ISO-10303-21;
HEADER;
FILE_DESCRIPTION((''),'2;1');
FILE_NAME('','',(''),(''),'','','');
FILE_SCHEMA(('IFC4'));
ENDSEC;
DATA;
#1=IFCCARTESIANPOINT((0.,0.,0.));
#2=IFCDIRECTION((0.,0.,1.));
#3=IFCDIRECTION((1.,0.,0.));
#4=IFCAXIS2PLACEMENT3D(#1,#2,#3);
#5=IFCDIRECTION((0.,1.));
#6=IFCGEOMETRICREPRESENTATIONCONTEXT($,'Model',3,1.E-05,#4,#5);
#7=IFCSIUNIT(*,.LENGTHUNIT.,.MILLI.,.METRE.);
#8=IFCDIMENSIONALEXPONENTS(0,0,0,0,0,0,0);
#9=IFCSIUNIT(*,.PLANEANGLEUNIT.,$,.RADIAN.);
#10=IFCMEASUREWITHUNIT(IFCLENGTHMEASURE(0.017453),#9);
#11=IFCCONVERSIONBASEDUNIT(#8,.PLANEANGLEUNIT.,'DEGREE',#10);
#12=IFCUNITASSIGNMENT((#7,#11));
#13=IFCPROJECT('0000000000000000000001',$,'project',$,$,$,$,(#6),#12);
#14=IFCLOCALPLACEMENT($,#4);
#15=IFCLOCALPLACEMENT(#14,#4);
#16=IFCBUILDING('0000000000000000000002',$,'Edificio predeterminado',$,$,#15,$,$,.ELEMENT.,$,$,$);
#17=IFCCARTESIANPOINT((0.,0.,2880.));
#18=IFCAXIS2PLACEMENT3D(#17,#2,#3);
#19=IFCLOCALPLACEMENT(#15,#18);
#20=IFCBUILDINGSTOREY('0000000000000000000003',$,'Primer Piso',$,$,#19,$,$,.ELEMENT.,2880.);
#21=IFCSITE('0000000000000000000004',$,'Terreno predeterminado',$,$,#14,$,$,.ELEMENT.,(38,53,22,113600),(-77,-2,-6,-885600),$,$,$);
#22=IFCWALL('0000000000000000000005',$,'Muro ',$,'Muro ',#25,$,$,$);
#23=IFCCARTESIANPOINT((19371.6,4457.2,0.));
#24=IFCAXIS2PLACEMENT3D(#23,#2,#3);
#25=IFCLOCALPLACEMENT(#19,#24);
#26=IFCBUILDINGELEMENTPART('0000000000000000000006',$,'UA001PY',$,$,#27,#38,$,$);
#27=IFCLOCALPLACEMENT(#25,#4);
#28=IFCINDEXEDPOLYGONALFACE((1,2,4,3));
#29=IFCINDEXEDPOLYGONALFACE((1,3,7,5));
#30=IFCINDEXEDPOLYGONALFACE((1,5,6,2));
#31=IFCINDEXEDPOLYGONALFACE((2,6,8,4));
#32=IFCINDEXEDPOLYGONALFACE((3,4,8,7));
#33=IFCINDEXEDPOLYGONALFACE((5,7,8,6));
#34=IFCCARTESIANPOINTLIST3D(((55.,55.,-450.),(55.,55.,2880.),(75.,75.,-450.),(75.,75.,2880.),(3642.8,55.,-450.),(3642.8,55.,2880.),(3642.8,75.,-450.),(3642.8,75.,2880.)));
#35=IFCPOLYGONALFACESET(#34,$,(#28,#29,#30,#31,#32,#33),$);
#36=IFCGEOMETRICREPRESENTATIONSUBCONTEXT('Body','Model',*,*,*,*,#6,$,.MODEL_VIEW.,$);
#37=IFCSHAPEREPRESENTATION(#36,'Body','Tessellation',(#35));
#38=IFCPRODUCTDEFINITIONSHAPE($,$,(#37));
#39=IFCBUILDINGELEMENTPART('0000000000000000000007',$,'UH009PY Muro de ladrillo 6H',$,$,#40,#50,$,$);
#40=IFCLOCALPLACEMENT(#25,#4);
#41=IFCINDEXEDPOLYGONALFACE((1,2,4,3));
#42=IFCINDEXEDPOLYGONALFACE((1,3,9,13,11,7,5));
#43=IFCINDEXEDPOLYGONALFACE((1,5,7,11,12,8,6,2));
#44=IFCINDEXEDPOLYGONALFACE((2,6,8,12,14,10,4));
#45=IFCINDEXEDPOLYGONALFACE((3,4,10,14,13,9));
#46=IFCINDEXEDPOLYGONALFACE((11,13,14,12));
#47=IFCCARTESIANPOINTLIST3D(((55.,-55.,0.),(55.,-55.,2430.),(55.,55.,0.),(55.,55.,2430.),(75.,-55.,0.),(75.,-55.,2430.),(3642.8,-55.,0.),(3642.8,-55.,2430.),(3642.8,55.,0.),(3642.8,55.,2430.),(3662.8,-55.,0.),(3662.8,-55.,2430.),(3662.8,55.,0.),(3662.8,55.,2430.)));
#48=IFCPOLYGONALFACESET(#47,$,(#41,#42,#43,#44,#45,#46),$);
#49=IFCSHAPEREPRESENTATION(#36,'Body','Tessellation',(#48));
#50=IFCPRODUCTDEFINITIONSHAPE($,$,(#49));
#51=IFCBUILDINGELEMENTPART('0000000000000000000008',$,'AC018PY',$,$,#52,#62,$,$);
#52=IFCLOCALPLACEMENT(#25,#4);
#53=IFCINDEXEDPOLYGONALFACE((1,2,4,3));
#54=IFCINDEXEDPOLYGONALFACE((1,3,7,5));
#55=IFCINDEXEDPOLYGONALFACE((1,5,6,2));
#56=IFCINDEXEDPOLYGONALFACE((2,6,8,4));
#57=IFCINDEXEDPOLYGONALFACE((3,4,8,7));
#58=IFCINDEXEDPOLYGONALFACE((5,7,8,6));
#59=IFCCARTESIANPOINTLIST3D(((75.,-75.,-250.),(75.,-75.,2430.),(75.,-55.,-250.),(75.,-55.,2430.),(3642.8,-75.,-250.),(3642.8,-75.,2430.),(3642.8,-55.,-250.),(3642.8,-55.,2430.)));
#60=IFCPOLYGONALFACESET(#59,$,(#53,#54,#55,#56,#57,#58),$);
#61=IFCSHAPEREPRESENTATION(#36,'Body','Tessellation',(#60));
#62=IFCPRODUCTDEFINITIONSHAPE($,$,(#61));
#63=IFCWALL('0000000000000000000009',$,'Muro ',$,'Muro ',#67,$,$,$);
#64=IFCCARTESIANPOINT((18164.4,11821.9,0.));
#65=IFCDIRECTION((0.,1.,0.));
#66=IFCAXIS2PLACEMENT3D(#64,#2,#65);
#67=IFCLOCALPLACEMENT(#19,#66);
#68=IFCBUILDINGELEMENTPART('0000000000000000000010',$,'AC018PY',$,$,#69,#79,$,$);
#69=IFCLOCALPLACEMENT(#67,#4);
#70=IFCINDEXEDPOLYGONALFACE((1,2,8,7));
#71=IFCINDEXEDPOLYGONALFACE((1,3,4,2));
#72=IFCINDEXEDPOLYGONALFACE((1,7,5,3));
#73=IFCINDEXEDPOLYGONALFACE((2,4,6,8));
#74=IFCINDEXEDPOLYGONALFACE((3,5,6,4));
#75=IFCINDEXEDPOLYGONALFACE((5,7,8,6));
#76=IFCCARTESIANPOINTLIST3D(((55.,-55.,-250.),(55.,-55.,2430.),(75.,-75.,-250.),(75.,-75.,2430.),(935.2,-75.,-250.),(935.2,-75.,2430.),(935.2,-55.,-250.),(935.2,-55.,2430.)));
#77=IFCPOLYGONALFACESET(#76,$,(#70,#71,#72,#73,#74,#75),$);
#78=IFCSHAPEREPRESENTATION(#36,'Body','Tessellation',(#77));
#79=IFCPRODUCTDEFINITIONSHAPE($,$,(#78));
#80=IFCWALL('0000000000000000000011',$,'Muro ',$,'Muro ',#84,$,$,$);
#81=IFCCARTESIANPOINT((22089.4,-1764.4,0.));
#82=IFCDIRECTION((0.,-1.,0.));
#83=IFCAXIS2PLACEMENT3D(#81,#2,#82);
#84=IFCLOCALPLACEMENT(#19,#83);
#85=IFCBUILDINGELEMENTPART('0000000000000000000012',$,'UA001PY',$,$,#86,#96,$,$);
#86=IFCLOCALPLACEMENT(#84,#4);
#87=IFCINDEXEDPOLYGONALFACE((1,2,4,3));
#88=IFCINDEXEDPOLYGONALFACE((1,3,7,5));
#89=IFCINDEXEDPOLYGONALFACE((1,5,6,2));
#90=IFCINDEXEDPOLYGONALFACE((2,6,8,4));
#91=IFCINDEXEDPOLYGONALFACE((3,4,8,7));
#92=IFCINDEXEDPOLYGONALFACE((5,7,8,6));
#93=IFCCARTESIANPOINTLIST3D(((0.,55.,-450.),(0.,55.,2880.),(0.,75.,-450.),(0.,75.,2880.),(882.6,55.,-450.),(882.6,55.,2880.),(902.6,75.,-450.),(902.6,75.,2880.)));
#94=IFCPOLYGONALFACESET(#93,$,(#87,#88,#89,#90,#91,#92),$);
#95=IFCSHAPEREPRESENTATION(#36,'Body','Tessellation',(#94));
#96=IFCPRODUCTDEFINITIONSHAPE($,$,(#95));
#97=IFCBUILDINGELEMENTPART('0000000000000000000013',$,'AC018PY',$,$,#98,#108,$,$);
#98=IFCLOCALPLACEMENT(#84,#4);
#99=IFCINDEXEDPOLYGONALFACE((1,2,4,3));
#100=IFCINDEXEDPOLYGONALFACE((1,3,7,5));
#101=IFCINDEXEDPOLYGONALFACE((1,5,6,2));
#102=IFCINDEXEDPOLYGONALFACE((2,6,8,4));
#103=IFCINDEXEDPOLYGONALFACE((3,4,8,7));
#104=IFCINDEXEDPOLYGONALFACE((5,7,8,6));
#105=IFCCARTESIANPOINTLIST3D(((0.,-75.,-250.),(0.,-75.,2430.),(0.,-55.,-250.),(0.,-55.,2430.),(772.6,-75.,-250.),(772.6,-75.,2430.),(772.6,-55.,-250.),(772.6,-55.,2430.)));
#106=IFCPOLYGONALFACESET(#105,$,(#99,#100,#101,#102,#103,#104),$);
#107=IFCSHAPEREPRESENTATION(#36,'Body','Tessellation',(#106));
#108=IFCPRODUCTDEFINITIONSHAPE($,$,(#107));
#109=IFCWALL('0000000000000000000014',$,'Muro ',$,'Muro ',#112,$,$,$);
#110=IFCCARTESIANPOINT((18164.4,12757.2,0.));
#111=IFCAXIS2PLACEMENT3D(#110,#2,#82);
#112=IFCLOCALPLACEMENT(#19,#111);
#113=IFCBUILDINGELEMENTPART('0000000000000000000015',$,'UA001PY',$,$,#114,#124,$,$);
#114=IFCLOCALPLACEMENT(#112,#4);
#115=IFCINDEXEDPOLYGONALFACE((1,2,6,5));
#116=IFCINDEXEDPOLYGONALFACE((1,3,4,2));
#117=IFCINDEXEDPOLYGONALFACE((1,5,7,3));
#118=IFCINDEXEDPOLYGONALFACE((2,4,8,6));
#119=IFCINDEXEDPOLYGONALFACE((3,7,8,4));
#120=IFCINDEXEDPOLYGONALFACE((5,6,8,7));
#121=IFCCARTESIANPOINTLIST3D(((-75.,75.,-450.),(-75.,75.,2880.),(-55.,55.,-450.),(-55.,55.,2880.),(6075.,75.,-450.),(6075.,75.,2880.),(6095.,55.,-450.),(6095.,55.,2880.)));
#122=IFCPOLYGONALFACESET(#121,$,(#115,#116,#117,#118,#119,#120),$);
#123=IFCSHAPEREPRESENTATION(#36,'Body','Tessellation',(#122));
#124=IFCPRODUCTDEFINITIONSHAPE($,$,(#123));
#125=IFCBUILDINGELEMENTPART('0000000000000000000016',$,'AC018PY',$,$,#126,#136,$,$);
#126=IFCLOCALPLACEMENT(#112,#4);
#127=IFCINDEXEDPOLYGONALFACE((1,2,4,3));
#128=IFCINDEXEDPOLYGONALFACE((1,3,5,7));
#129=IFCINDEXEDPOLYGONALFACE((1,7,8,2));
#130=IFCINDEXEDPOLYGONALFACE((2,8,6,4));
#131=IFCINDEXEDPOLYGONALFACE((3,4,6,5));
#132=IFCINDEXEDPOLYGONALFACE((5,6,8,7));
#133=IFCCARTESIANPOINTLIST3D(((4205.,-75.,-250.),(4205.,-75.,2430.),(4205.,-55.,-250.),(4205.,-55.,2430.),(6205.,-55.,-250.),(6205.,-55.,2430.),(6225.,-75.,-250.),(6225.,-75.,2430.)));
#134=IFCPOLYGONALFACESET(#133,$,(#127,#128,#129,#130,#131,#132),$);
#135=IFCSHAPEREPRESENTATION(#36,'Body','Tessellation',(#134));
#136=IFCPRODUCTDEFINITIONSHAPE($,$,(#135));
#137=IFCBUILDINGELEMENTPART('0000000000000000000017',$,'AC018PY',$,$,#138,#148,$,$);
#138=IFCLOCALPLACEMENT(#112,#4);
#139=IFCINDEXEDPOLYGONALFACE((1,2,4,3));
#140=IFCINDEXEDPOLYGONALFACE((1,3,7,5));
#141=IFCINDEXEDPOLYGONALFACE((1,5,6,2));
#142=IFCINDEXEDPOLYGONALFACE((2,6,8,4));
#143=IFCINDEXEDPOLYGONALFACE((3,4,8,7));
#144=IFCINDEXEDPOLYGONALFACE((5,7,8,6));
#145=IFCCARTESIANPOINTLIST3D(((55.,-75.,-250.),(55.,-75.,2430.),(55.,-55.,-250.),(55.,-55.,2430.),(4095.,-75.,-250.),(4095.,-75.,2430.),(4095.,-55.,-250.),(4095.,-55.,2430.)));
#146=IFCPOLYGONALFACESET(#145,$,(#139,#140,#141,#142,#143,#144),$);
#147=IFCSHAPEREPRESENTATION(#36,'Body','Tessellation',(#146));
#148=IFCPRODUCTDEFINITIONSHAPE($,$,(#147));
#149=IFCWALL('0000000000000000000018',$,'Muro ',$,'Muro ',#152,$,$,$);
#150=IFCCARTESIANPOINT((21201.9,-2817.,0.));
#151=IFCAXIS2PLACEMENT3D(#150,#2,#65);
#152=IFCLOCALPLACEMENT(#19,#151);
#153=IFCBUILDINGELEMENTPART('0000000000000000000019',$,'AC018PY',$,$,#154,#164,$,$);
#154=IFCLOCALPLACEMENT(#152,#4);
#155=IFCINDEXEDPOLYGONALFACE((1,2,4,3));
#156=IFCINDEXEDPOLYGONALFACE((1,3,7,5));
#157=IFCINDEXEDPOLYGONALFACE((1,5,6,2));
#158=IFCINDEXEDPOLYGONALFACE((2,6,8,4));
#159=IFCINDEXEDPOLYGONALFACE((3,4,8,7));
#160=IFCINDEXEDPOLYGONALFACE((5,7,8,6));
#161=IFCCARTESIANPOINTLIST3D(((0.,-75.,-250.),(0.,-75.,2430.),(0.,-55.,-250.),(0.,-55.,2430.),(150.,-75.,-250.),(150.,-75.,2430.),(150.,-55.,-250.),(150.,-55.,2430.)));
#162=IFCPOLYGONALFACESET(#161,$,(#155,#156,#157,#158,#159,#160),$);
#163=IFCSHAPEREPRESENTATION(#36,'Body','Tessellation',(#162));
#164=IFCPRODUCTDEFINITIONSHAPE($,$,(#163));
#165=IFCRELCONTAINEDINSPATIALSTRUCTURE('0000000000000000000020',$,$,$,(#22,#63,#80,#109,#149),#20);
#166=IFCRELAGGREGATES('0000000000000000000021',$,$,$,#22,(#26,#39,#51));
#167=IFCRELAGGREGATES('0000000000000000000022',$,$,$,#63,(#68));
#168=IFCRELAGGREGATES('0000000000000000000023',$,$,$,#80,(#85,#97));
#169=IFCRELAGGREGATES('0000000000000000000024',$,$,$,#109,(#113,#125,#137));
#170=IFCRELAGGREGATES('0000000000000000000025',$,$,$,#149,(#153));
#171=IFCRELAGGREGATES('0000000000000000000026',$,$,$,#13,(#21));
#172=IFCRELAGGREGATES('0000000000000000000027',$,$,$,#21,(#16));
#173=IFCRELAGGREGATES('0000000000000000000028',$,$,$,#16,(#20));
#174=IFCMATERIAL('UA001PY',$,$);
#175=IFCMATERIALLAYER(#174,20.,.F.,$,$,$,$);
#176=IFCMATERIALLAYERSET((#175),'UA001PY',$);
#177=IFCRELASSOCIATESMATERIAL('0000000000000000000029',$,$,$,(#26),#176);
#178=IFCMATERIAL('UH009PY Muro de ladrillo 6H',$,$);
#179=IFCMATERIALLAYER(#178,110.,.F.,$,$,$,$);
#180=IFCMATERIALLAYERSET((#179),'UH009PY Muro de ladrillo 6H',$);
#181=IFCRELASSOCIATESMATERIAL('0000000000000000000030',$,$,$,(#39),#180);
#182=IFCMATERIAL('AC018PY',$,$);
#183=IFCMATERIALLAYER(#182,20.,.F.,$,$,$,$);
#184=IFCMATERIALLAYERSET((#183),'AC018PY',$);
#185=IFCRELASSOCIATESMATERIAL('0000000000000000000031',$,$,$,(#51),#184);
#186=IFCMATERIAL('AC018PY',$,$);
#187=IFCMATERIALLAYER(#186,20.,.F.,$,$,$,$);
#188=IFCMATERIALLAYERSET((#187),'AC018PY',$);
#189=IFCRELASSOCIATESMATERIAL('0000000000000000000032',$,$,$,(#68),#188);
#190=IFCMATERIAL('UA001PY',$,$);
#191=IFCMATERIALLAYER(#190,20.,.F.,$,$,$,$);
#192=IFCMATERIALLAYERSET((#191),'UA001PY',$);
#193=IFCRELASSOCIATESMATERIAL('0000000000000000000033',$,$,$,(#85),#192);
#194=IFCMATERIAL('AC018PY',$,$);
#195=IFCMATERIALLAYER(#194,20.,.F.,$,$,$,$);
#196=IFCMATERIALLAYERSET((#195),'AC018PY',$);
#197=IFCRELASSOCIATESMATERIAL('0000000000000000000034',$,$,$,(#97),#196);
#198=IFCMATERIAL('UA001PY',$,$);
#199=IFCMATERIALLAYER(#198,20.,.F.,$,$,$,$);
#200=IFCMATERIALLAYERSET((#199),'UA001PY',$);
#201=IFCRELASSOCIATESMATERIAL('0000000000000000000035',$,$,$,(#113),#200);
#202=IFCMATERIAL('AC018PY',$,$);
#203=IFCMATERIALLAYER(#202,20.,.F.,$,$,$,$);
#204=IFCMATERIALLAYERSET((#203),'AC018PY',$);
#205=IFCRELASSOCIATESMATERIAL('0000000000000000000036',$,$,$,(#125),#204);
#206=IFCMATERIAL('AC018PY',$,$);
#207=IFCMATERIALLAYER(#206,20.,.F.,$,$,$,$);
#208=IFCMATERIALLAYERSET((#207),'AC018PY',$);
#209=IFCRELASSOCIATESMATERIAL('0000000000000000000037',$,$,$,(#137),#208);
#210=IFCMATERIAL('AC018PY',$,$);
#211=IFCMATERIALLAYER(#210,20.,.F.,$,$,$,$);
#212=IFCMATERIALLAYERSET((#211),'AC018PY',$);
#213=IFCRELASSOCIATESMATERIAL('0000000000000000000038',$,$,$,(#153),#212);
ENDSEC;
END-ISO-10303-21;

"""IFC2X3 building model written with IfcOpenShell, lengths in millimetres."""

from ifc_helpers import new_model, entity, si_unit, converted_unit, direction, frame, origin_with_axes, place, context, subcontext, project, spatial, polyline, outline, extrude, clip, bounded_halfspace, material, layer, layer_set, layer_usage, element, aggregate, save


model = new_model("IFC2X3")

# Units and contexts
model_context = context("Model", 3, precision=1e-05, world=origin_with_axes(), true_north=direction((0.0, 1.0)))
body_context = subcontext(model_context, "Body", "Model", "MODEL_VIEW")
ifc_project = project(units=[si_unit("LENGTHUNIT", "METRE", prefix="MILLI"), converted_unit("PLANEANGLEUNIT", "DEGREE", entity("IfcLengthMeasure", 0.017453), si_unit("PLANEANGLEUNIT", "RADIAN"), dimensions=[0, 0, 0, 0, 0, 0, 0])], contexts=[model_context])

# Site, building, storey
site_placement = place(None, origin_with_axes())
site = spatial("IfcSite", under=ifc_project, at=site_placement, Name="Terreno predeterminado", CompositionType="ELEMENT", RefLatitude=(38, 53, 22, 113600), RefLongitude=(-77, -2, -6, -885600))
building_placement = place(site_placement, origin_with_axes())
building = spatial("IfcBuilding", under=site, at=building_placement, Name="Edificio predeterminado", CompositionType="ELEMENT")
storey_placement = place(building_placement, frame((0.0, 0.0, 2880.0), z_axis=(0.0, 0.0, 1.0), x_axis=(1.0, 0.0, 0.0)))
storey = spatial("IfcBuildingStorey", under=building, at=storey_placement, Name="Primer Piso", CompositionType="ELEMENT", Elevation=2880.0)

# Walls, building element parts
wall_1_placement = place(storey_placement, frame((19371.6, 4457.2, 0.0), z_axis=(0.0, 0.0, 1.0), x_axis=(1.0, 0.0, 0.0)))
wall_1 = element("IfcWall", 1, at=wall_1_placement, inside=storey, Name="Muro ", ObjectType="Muro ")
ifc_material_1 = material(Name="UA001PY")
ifc_layer_1 = layer(ifc_material_1, 20.0, ventilated=False)
ifc_layer_set_1 = layer_set([ifc_layer_1], Name="UA001PY")
ifc_layer_usage_1 = layer_usage(ifc_layer_set_1, "AXIS2", "NEGATIVE", -75.0)
building_element_part_1_placement = place(wall_1_placement, origin_with_axes())
building_element_part_1 = element("IfcBuildingElementPart", 2, at=building_element_part_1_placement, material=ifc_layer_usage_1, Name="UA001PY", context=body_context, shape_type="SweptSolid", body=[
    extrude(outline(polyline([(3642.8, 75.0), (3642.8, 55.0), (55.0, 55.0), (75.0, 75.0), (3642.8, 75.0)])), frame((0.0, 0.0, -450.0), z_axis=(0.0, 0.0, 1.0), x_axis=(1.0, 0.0, 0.0)), (0.0, 0.0, 1.0), 3330.0),
])
ifc_material_2 = material(Name="UH009PY Muro de ladrillo 6H")
ifc_layer_2 = layer(ifc_material_2, 110.0, ventilated=False)
ifc_layer_set_2 = layer_set([ifc_layer_2], Name="UH009PY Muro de ladrillo 6H")
ifc_layer_usage_2 = layer_usage(ifc_layer_set_2, "AXIS2", "NEGATIVE", -55.0)
building_element_part_2_placement = place(wall_1_placement, origin_with_axes())
building_element_part_2 = element("IfcBuildingElementPart", 3, at=building_element_part_2_placement, material=ifc_layer_usage_2, Name="UH009PY Muro de ladrillo 6H", context=body_context, shape_type="SweptSolid", body=[
    extrude(outline(polyline([(3662.8, 55.0), (3662.8, -55.0), (3642.8, -55.0), (75.0, -55.0), (55.0, -55.0), (55.0, 55.0), (3642.8, 55.0), (3662.8, 55.0)])), origin_with_axes(), (0.0, 0.0, 1.0), 2430.0),
])
ifc_material_3 = material(Name="AC018PY")
ifc_layer_3 = layer(ifc_material_3, 20.0, ventilated=False)
ifc_layer_set_3 = layer_set([ifc_layer_3], Name="AC018PY")
ifc_layer_usage_3 = layer_usage(ifc_layer_set_3, "AXIS2", "NEGATIVE", 55.0)
building_element_part_3_placement = place(wall_1_placement, origin_with_axes())
building_element_part_3 = element("IfcBuildingElementPart", 4, at=building_element_part_3_placement, material=ifc_layer_usage_3, Name="AC018PY", context=body_context, shape_type="SweptSolid", body=[
    extrude(outline(polyline([(3642.8, -55.0), (3642.8, -75.0), (75.0, -75.0), (75.0, -55.0), (3642.8, -55.0)])), frame((0.0, 0.0, -250.0), z_axis=(0.0, 0.0, 1.0), x_axis=(1.0, 0.0, 0.0)), (0.0, 0.0, 1.0), 2680.0),
])
aggregate(wall_1, [building_element_part_1, building_element_part_2, building_element_part_3])
wall_2_placement = place(storey_placement, frame((18164.4, 11821.9, 0.0), z_axis=(0.0, 0.0, 1.0), x_axis=(0.0, 1.0, 0.0)))
wall_2 = element("IfcWall", 5, at=wall_2_placement, inside=storey, Name="Muro ", ObjectType="Muro ")
ifc_material_4 = material(Name="AC018PY")
ifc_layer_4 = layer(ifc_material_4, 20.0, ventilated=False)
ifc_layer_set_4 = layer_set([ifc_layer_4], Name="AC018PY")
ifc_layer_usage_4 = layer_usage(ifc_layer_set_4, "AXIS2", "NEGATIVE", 55.0)
building_element_part_4_placement = place(wall_2_placement, origin_with_axes())
building_element_part_4 = element("IfcBuildingElementPart", 6, at=building_element_part_4_placement, material=ifc_layer_usage_4, Name="AC018PY", context=body_context, shape_type="SweptSolid", body=[
    extrude(outline(polyline([(935.2, -55.0), (935.2, -75.0), (75.0, -75.0), (55.0, -55.0), (935.2, -55.0)])), frame((0.0, 0.0, -250.0), z_axis=(0.0, 0.0, 1.0), x_axis=(1.0, 0.0, 0.0)), (0.0, 0.0, 1.0), 2680.0),
])
aggregate(wall_2, [building_element_part_4])
wall_3_placement = place(storey_placement, frame((22089.4, -1764.4, 0.0), z_axis=(0.0, 0.0, 1.0), x_axis=(0.0, -1.0, 0.0)))
wall_3 = element("IfcWall", 7, at=wall_3_placement, inside=storey, Name="Muro ", ObjectType="Muro ")
ifc_material_5 = material(Name="UA001PY")
ifc_layer_5 = layer(ifc_material_5, 20.0, ventilated=False)
ifc_layer_set_5 = layer_set([ifc_layer_5], Name="UA001PY")
ifc_layer_usage_5 = layer_usage(ifc_layer_set_5, "AXIS2", "NEGATIVE", -75.0)
building_element_part_5_placement = place(wall_3_placement, origin_with_axes())
building_element_part_5 = element("IfcBuildingElementPart", 8, at=building_element_part_5_placement, material=ifc_layer_usage_5, Name="UA001PY", context=body_context, shape_type="SweptSolid", body=[
    extrude(outline(polyline([(902.6, 75.0), (882.6, 55.0), (0.0, 55.0), (0.0, 75.0), (902.6, 75.0)])), frame((0.0, 0.0, -450.0), z_axis=(0.0, 0.0, 1.0), x_axis=(1.0, 0.0, 0.0)), (0.0, 0.0, 1.0), 3330.0),
])
ifc_material_6 = material(Name="AC018PY")
ifc_layer_6 = layer(ifc_material_6, 20.0, ventilated=False)
ifc_layer_set_6 = layer_set([ifc_layer_6], Name="AC018PY")
ifc_layer_usage_6 = layer_usage(ifc_layer_set_6, "AXIS2", "NEGATIVE", 55.0)
building_element_part_6_placement = place(wall_3_placement, origin_with_axes())
building_element_part_6 = element("IfcBuildingElementPart", 9, at=building_element_part_6_placement, material=ifc_layer_usage_6, Name="AC018PY", context=body_context, shape_type="SweptSolid", body=[
    extrude(outline(polyline([(772.6, -55.0), (772.6, -75.0), (0.0, -75.0), (0.0, -55.0), (772.6, -55.0)])), frame((0.0, 0.0, -250.0), z_axis=(0.0, 0.0, 1.0), x_axis=(1.0, 0.0, 0.0)), (0.0, 0.0, 1.0), 2680.0),
])
aggregate(wall_3, [building_element_part_5, building_element_part_6])
wall_4_placement = place(storey_placement, frame((18164.4, 12757.2, 0.0), z_axis=(0.0, 0.0, 1.0), x_axis=(0.0, -1.0, 0.0)))
wall_4 = element("IfcWall", 10, at=wall_4_placement, inside=storey, Name="Muro ", ObjectType="Muro ")
ifc_material_7 = material(Name="UA001PY")
ifc_layer_7 = layer(ifc_material_7, 20.0, ventilated=False)
ifc_layer_set_7 = layer_set([ifc_layer_7], Name="UA001PY")
ifc_layer_usage_7 = layer_usage(ifc_layer_set_7, "AXIS2", "NEGATIVE", -75.0)
building_element_part_7_placement = place(wall_4_placement, origin_with_axes())
building_element_part_7 = element("IfcBuildingElementPart", 11, at=building_element_part_7_placement, material=ifc_layer_usage_7, Name="UA001PY", context=body_context, shape_type="SweptSolid", body=[
    extrude(outline(polyline([(6075.0, 75.0), (6095.0, 55.0), (-55.0, 55.0), (-75.0, 75.0), (6075.0, 75.0)])), frame((0.0, 0.0, -450.0), z_axis=(0.0, 0.0, 1.0), x_axis=(1.0, 0.0, 0.0)), (0.0, 0.0, 1.0), 3330.0),
])
ifc_material_8 = material(Name="AC018PY")
ifc_layer_8 = layer(ifc_material_8, 20.0, ventilated=False)
ifc_layer_set_8 = layer_set([ifc_layer_8], Name="AC018PY")
ifc_layer_usage_8 = layer_usage(ifc_layer_set_8, "AXIS2", "NEGATIVE", 55.0)
building_element_part_8_placement = place(wall_4_placement, origin_with_axes())
building_element_part_8 = element("IfcBuildingElementPart", 12, at=building_element_part_8_placement, material=ifc_layer_usage_8, Name="AC018PY", context=body_context, shape_type="SweptSolid", body=[
    extrude(outline(polyline([(6205.0, -55.0), (6225.0, -75.0), (4205.0, -75.0), (4205.0, -55.0), (6205.0, -55.0)])), frame((0.0, 0.0, -250.0), z_axis=(0.0, 0.0, 1.0), x_axis=(1.0, 0.0, 0.0)), (0.0, 0.0, 1.0), 2680.0),
])
ifc_material_9 = material(Name="AC018PY")
ifc_layer_9 = layer(ifc_material_9, 20.0, ventilated=False)
ifc_layer_set_9 = layer_set([ifc_layer_9], Name="AC018PY")
ifc_layer_usage_9 = layer_usage(ifc_layer_set_9, "AXIS2", "NEGATIVE", 55.0)
building_element_part_9_placement = place(wall_4_placement, origin_with_axes())
building_element_part_9 = element("IfcBuildingElementPart", 13, at=building_element_part_9_placement, material=ifc_layer_usage_9, Name="AC018PY", context=body_context, shape_type="SweptSolid", body=[
    extrude(outline(polyline([(4095.0, -55.0), (4095.0, -75.0), (55.0, -75.0), (55.0, -55.0), (4095.0, -55.0)])), frame((0.0, 0.0, -250.0), z_axis=(0.0, 0.0, 1.0), x_axis=(1.0, 0.0, 0.0)), (0.0, 0.0, 1.0), 2680.0),
])
aggregate(wall_4, [building_element_part_7, building_element_part_8, building_element_part_9])
wall_5_placement = place(storey_placement, frame((21201.9, -2817.0, 0.0), z_axis=(0.0, 0.0, 1.0), x_axis=(0.0, 1.0, 0.0)))
wall_5 = element("IfcWall", 14, at=wall_5_placement, inside=storey, Name="Muro ", ObjectType="Muro ")
ifc_material_10 = material(Name="AC018PY")
ifc_layer_10 = layer(ifc_material_10, 20.0, ventilated=False)
ifc_layer_set_10 = layer_set([ifc_layer_10], Name="AC018PY")
ifc_layer_usage_10 = layer_usage(ifc_layer_set_10, "AXIS2", "NEGATIVE", 55.0)
building_element_part_10_placement = place(wall_5_placement, origin_with_axes())
building_element_part_10 = element("IfcBuildingElementPart", 15, at=building_element_part_10_placement, material=ifc_layer_usage_10, Name="AC018PY", context=body_context, shape_type="Clipping", body=[
    clip(clip(extrude(outline(polyline([(150.0, -55.0), (150.0, -75.0), (0.0, -75.0), (0.0, -55.0), (150.0, -55.0)])), frame((0.0, 0.0, -250.0), z_axis=(0.0, 0.0, 1.0), x_axis=(1.0, 0.0, 0.0)), (0.0, 0.0, 1.0), 2680.0), bounded_halfspace(frame((0.0, 0.0, -250.0), z_axis=(0.0, 0.0, 1.0), x_axis=(1.0, 0.0, 0.0)), True, origin_with_axes(), polyline([(-150.0, -150.0), (375.0, -150.0), (375.0, 150.0), (-150.0, 150.0), (-150.0, -150.0)]))), bounded_halfspace(frame((0.0, 0.0, 2430.0), z_axis=(0.0, 0.0, 1.0), x_axis=(1.0, 0.0, 0.0)), False, origin_with_axes(), polyline([(-150.0, -150.0), (375.0, -150.0), (375.0, 150.0), (-150.0, 150.0), (-150.0, -150.0)]))),
])
aggregate(wall_5, [building_element_part_10])

save(model, "model.ifc")
